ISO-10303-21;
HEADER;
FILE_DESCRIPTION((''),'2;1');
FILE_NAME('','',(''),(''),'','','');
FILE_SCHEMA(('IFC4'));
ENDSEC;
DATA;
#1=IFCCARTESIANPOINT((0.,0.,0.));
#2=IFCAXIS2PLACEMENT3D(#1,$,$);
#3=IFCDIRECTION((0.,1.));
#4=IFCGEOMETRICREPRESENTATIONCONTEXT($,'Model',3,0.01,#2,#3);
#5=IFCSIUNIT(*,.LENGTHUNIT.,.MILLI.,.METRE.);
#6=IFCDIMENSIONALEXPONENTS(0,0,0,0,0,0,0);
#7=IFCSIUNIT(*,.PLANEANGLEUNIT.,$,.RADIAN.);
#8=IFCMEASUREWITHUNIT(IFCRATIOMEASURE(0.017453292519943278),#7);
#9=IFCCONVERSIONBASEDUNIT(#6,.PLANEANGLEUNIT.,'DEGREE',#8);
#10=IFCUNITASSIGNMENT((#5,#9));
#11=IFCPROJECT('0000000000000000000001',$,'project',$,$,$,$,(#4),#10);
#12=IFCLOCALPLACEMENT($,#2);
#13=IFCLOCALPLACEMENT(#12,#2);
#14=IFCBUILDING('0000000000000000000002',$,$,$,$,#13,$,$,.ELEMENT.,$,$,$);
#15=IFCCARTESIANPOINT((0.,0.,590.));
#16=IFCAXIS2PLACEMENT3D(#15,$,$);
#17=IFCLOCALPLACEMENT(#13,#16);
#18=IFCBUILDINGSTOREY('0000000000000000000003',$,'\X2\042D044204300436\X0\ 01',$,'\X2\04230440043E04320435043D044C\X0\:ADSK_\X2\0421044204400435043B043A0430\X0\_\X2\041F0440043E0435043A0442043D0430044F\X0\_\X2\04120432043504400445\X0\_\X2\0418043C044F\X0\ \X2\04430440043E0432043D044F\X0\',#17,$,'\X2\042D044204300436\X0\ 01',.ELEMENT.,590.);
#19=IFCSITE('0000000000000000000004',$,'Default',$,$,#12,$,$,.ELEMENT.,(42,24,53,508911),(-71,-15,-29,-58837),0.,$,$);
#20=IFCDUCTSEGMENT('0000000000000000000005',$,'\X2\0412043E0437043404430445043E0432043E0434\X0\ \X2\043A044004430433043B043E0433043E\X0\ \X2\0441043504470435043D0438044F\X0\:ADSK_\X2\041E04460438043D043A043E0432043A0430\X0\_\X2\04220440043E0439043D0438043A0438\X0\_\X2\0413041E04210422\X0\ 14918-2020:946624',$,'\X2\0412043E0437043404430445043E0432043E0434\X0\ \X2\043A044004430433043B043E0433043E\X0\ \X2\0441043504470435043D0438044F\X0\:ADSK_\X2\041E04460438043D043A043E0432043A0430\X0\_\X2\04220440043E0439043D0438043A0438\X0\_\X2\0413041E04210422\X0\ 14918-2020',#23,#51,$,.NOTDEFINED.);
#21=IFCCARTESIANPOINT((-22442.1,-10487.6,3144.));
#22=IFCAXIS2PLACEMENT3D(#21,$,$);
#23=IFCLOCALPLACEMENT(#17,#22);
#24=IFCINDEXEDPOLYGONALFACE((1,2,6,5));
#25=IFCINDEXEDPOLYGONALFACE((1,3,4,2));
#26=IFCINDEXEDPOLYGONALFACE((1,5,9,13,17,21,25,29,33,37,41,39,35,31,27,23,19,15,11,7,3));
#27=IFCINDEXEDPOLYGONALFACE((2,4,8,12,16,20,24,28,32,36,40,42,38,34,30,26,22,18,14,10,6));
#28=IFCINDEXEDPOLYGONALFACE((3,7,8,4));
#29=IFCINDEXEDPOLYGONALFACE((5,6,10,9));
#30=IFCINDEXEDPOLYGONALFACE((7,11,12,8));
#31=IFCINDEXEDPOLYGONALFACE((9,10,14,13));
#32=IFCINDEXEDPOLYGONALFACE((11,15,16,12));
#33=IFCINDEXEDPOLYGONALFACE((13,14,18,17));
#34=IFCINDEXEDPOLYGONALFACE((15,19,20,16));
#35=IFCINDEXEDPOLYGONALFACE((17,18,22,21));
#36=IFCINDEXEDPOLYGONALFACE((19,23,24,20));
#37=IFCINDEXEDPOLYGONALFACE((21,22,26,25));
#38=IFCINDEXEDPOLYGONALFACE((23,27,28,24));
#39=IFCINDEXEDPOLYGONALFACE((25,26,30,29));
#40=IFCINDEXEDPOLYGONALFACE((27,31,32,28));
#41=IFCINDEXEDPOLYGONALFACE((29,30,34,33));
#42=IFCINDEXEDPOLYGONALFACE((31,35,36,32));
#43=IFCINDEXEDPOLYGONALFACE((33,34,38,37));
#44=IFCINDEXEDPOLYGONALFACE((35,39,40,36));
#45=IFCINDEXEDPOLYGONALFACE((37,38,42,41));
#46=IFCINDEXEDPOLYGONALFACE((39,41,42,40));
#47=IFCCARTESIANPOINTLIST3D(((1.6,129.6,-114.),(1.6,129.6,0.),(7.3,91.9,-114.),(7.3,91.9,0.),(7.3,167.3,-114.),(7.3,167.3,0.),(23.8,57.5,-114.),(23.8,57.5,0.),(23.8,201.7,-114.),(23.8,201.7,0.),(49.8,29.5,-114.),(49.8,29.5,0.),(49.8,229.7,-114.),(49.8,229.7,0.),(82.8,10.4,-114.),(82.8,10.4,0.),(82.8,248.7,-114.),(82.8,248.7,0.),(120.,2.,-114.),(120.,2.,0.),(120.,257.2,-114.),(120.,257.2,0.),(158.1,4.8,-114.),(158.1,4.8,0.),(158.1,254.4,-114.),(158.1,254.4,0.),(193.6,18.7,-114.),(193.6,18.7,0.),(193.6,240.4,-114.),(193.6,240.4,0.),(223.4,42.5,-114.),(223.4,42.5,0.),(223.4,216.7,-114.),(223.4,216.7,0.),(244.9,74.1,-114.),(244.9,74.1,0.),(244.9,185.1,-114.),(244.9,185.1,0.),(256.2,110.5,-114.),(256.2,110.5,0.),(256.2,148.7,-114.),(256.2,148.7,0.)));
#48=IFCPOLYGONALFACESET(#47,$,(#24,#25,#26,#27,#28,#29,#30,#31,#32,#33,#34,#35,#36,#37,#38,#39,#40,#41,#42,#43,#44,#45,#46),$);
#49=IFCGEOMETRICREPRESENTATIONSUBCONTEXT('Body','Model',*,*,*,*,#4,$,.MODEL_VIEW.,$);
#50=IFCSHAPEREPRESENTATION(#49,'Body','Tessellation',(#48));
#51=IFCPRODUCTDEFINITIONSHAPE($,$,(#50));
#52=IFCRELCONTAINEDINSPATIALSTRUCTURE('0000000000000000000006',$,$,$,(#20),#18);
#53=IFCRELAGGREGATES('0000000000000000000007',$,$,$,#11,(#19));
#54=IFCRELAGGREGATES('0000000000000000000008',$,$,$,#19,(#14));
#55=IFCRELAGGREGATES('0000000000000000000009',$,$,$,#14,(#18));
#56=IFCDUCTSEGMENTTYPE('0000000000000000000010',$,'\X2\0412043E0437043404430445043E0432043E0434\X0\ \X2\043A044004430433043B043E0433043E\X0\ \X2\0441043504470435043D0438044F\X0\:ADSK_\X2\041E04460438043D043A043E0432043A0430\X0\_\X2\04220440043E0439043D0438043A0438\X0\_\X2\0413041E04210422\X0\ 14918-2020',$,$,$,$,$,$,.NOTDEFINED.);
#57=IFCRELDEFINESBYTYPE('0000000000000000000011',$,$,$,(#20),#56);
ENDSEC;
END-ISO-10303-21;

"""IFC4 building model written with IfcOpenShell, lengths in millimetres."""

from ifc_helpers import new_model, entity, si_unit, converted_unit, direction, frame, origin, origin_2d_with_axis, place, context, subcontext, project, spatial, circle, extrude, type_object, element, save


model = new_model("IFC4")

# Units and contexts
model_context = context("Model", 3, precision=0.01, world=origin(), true_north=direction((0.0, 1.0)))
body_context = subcontext(model_context, "Body", "Model", "MODEL_VIEW")
ifc_project = project(units=[si_unit("LENGTHUNIT", "METRE", prefix="MILLI"), converted_unit("PLANEANGLEUNIT", "DEGREE", entity("IfcRatioMeasure", 0.017453292519943278), si_unit("PLANEANGLEUNIT", "RADIAN"), dimensions=[0, 0, 0, 0, 0, 0, 0])], contexts=[model_context])

# Site, building, storey
site_placement = place(None, origin())
site = spatial("IfcSite", under=ifc_project, at=site_placement, Name="Default", CompositionType="ELEMENT", RefLatitude=(42, 24, 53, 508911), RefLongitude=(-71, -15, -29, -58837), RefElevation=0.0)
building_placement = place(site_placement, origin())
building = spatial("IfcBuilding", under=site, at=building_placement, CompositionType="ELEMENT")
storey_placement = place(building_placement, frame((0.0, 0.0, 590.0)))
storey = spatial("IfcBuildingStorey", under=building, at=storey_placement, Name="Этаж 01", ObjectType="Уровень:ADSK_Стрелка_Проектная_Вверх_Имя уровня", LongName="Этаж 01", CompositionType="ELEMENT", Elevation=590.0)

# Duct segment
duct_segment_type = type_object("IfcDuctSegmentType", Name="Воздуховод круглого сечения:ADSK_Оцинковка_Тройники_ГОСТ 14918-2020", PredefinedType="NOTDEFINED")
duct_segment_1_placement = place(storey_placement, frame((-22442.1, -10487.6, 3144.0)))
element("IfcDuctSegment", 1, at=duct_segment_1_placement, inside=storey, type_object=duct_segment_type, Name="Воздуховод круглого сечения:ADSK_Оцинковка_Тройники_ГОСТ 14918-2020:946624", ObjectType="Воздуховод круглого сечения:ADSK_Оцинковка_Тройники_ГОСТ 14918-2020", PredefinedType="NOTDEFINED", context=body_context, shape_type="SweptSolid", body=[
    extrude(circle(Radius=128.0, at=origin_2d_with_axis()), frame((129.6, 129.6, -114.0), z_axis=(0.0, 0.0, 1.0), x_axis=(-1.0, 0.0, 0.0)), (0.0, 0.0, 1.0), 114.0),
])

save(model, "model.ifc")
